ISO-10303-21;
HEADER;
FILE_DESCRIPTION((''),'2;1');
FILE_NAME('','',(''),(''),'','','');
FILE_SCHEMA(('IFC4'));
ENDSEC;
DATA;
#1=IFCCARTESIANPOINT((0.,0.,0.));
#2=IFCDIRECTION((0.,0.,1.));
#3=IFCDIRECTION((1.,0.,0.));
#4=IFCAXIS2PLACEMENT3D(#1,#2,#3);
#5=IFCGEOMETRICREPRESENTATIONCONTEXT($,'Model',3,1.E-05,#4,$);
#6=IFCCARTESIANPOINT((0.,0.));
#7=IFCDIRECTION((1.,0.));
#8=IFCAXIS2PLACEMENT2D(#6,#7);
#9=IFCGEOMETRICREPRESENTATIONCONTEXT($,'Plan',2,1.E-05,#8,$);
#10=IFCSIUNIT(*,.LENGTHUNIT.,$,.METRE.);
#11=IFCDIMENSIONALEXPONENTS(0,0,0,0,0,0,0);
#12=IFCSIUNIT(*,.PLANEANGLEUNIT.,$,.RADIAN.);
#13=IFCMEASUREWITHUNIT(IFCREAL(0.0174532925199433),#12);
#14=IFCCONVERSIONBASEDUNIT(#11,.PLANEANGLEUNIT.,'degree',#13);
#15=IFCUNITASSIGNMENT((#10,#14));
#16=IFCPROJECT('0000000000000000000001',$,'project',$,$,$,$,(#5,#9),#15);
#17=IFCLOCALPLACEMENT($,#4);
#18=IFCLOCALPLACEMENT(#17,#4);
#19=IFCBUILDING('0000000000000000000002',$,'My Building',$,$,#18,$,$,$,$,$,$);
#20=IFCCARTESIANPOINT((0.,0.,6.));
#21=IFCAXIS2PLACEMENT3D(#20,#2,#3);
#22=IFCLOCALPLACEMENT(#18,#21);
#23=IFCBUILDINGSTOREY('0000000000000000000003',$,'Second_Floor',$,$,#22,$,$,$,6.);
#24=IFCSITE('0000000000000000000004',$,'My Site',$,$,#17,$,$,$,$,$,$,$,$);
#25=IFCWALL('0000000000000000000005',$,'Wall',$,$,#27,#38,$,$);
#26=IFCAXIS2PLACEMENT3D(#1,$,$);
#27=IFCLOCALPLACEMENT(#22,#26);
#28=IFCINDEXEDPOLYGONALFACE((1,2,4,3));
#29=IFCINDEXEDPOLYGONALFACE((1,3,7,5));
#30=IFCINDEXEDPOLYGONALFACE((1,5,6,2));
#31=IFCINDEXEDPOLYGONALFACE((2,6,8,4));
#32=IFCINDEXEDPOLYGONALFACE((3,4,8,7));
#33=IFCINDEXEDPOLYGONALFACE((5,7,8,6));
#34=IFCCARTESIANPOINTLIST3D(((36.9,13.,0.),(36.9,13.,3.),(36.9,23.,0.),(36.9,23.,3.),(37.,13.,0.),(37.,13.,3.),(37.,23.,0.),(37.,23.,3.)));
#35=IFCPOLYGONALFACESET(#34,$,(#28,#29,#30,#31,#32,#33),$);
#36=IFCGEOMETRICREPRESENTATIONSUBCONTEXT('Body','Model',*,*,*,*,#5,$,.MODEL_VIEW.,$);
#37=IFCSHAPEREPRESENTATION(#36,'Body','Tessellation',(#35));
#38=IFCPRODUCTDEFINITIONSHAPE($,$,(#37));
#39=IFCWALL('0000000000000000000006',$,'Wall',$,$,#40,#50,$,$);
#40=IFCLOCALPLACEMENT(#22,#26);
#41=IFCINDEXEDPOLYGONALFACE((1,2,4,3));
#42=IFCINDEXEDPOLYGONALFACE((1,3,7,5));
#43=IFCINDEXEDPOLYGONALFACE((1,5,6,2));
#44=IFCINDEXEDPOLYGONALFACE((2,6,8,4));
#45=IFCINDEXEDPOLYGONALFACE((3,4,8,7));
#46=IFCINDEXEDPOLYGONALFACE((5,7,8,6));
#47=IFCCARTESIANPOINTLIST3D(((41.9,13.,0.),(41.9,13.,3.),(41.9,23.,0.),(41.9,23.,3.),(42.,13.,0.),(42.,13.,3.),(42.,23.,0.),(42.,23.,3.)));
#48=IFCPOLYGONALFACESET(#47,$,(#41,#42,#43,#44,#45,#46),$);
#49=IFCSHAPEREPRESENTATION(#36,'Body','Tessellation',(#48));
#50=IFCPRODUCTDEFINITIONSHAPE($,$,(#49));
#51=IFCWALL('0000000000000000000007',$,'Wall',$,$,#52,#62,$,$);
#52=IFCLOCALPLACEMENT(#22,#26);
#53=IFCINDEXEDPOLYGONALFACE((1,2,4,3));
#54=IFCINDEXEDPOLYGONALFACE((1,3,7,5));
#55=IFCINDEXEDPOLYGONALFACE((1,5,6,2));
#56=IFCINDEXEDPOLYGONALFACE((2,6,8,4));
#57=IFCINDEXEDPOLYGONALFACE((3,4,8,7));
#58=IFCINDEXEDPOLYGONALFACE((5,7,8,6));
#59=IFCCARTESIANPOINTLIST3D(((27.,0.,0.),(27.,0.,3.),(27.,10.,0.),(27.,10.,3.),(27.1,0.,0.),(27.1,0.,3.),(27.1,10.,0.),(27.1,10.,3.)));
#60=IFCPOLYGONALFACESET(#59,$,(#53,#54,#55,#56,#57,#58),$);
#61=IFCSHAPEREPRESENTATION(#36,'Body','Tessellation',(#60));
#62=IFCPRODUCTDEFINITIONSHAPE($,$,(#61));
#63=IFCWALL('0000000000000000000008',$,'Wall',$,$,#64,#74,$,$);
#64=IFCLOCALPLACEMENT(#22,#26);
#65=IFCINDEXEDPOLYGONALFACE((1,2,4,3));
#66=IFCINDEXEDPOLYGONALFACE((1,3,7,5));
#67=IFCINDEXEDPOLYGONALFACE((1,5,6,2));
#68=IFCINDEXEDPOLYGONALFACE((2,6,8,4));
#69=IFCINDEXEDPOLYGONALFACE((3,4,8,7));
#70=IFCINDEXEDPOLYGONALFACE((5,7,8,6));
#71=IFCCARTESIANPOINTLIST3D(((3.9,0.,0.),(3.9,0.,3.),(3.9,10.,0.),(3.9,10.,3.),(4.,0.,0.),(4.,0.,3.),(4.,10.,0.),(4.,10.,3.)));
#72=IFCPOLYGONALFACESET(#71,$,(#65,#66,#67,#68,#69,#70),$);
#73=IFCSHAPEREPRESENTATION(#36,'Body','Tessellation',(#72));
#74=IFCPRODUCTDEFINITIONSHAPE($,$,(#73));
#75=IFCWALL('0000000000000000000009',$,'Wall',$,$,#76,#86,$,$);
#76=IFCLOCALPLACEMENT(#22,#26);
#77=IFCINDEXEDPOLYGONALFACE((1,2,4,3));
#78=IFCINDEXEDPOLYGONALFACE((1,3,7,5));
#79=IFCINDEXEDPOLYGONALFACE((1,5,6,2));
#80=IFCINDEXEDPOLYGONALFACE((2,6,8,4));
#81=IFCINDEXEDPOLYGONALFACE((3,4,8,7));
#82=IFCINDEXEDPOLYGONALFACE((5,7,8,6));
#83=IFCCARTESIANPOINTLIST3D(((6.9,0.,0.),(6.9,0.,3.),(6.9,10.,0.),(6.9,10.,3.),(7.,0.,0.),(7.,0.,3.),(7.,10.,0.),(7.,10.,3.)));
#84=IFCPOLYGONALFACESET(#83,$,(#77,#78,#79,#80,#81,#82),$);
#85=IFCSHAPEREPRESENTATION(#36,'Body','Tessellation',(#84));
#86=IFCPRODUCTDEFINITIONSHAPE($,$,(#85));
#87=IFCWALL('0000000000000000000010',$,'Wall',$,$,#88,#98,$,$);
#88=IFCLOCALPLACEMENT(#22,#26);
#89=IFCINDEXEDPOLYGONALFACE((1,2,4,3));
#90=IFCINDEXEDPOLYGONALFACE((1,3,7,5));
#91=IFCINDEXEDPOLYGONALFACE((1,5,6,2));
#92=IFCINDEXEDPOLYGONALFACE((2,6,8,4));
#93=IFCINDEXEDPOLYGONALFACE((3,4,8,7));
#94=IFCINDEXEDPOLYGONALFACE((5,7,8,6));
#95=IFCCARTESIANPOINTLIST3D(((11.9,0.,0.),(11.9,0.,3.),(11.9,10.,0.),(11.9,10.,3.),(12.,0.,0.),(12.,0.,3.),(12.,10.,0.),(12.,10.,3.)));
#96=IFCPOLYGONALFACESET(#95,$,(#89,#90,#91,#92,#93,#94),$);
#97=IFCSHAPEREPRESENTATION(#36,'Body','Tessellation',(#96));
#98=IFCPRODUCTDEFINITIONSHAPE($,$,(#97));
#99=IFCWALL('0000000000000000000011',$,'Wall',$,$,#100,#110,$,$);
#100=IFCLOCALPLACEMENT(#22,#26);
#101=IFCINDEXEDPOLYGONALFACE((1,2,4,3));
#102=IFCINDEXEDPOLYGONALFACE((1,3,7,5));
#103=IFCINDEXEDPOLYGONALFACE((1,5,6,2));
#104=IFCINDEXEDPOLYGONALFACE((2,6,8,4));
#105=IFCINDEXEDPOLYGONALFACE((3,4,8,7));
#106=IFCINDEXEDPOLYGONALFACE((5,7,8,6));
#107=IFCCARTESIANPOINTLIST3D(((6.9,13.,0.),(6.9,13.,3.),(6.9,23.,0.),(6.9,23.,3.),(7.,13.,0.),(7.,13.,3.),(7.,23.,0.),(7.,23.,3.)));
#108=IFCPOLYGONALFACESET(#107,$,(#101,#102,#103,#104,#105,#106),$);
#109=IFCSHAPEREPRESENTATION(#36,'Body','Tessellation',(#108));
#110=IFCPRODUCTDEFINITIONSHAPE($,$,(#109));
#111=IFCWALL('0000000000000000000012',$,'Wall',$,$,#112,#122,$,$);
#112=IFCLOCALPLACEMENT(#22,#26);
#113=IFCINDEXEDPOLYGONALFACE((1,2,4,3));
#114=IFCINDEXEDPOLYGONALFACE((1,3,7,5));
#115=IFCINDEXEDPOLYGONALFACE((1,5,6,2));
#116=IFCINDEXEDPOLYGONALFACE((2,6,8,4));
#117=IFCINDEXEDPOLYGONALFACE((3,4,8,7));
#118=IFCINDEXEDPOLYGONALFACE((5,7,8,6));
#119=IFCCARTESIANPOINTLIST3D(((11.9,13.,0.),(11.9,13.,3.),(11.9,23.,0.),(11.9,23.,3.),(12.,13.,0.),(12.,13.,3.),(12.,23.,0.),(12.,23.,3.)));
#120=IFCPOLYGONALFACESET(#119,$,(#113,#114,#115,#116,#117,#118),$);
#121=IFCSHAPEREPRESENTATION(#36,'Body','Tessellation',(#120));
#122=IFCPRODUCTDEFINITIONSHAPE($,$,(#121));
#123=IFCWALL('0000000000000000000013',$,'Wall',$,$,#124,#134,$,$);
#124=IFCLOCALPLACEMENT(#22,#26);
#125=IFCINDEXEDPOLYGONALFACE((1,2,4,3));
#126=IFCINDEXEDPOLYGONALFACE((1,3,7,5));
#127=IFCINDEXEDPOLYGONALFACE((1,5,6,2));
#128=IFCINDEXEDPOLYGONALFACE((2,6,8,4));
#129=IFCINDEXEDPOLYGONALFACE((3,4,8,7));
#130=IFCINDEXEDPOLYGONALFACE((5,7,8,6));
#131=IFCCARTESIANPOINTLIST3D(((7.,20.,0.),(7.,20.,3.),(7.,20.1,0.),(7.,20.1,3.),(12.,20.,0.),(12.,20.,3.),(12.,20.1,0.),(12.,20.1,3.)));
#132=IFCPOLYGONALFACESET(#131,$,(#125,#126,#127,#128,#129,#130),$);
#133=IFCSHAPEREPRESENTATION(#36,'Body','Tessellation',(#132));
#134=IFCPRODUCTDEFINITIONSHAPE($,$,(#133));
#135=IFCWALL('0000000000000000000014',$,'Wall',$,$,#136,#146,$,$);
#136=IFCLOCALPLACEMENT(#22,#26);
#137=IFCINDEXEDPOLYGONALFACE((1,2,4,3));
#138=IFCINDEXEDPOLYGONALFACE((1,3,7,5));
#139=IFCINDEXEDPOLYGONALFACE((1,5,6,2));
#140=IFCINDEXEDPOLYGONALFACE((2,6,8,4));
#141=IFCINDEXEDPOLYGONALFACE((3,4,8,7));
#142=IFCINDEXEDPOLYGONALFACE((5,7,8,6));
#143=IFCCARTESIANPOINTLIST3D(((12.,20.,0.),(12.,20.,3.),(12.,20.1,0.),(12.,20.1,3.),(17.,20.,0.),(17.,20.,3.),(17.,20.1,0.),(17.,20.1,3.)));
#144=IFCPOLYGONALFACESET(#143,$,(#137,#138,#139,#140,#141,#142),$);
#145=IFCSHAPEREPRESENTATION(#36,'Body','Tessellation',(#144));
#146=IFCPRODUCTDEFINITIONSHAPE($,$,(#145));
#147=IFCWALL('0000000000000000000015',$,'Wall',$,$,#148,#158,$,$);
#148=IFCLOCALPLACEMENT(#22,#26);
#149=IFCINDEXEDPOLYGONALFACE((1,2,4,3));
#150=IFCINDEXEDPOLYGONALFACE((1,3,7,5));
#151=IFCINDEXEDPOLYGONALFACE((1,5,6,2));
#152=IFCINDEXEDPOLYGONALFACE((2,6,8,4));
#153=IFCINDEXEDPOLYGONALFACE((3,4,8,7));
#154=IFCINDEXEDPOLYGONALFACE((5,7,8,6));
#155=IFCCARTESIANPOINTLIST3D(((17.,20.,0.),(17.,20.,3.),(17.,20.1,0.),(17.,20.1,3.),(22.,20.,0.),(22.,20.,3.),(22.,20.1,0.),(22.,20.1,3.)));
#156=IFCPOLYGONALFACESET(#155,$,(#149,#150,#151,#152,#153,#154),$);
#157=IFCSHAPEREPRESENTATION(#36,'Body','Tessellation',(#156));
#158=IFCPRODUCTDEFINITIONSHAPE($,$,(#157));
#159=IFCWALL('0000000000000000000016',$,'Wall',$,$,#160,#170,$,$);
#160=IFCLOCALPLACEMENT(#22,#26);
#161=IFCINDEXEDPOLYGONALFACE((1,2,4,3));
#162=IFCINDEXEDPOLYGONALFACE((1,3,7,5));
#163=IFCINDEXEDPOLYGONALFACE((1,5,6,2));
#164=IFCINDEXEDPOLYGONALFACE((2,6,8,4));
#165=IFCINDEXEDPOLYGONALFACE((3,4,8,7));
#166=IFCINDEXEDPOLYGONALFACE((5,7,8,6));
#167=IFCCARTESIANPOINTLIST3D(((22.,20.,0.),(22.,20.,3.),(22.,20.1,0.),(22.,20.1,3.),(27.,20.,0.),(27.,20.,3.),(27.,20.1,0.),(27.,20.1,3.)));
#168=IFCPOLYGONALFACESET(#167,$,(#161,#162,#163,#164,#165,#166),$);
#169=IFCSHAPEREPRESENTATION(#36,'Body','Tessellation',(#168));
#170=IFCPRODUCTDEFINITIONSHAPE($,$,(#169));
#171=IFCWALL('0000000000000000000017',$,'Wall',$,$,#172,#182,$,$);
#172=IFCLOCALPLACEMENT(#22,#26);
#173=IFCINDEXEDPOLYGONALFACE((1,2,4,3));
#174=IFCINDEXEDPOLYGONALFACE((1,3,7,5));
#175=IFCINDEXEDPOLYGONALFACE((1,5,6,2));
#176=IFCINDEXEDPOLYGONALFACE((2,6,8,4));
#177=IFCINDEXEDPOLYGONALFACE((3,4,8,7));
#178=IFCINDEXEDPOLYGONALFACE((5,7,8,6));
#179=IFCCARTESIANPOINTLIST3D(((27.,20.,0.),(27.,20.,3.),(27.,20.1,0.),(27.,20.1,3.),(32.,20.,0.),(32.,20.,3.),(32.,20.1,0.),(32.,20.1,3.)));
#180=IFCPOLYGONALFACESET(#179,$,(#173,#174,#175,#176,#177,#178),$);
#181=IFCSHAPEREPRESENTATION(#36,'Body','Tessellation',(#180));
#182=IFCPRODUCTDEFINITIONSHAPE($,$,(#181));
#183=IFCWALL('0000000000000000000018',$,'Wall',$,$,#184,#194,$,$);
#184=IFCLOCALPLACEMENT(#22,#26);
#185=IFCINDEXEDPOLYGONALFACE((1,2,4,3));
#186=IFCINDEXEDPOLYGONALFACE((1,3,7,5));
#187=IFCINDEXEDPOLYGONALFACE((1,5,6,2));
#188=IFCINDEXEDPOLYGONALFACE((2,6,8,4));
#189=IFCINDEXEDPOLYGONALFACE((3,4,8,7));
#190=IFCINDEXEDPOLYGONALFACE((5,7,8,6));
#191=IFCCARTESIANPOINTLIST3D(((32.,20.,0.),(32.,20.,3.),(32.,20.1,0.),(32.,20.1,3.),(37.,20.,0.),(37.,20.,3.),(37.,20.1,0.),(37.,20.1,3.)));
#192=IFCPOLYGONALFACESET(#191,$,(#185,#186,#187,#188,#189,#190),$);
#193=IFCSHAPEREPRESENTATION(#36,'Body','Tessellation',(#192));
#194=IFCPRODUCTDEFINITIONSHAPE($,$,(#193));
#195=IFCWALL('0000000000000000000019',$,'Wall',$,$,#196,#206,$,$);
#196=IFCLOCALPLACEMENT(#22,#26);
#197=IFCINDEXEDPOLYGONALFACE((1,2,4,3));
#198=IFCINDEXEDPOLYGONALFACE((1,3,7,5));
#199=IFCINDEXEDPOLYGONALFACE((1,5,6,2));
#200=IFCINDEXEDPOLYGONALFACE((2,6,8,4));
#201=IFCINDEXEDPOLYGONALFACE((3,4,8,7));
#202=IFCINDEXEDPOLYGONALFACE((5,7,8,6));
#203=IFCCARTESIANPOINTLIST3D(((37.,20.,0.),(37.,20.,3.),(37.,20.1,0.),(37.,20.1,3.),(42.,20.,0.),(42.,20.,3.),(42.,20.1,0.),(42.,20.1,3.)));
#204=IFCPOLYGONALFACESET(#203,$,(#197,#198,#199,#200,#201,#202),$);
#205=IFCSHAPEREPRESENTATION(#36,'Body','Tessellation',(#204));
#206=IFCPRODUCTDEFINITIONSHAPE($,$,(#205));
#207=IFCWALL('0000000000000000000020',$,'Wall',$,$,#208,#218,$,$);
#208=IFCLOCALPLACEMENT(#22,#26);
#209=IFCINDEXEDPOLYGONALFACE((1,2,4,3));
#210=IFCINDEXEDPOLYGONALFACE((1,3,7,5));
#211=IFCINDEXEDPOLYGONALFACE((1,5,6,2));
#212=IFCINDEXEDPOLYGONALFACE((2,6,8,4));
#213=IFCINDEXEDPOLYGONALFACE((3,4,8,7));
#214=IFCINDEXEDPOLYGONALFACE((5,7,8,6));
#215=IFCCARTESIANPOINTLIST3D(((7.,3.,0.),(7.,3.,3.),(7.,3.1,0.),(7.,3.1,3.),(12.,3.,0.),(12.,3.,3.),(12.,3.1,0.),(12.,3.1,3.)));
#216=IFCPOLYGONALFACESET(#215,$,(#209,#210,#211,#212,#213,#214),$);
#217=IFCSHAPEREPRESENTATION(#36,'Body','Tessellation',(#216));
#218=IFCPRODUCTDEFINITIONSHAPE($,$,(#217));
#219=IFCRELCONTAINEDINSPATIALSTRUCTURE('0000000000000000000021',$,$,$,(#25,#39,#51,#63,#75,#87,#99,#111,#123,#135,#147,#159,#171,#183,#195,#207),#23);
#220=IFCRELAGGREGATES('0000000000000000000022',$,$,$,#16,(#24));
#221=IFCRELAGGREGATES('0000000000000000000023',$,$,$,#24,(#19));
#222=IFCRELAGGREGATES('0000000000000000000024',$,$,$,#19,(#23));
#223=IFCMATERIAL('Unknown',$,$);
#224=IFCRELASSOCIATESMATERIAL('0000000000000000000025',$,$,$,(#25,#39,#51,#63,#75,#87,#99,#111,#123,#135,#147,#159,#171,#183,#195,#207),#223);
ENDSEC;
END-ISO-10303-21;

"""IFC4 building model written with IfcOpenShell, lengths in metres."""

from ifc_helpers import new_model, entity, si_unit, converted_unit, frame, frame_2d, origin, origin_with_axes, origin_2d_with_axis, place, context, subcontext, project, spatial, rectangle, extrude, material, element, save


model = new_model("IFC4")

# Units and contexts
model_context = context("Model", 3, precision=1e-05, world=origin_with_axes())
plan_context = context("Plan", 2, precision=1e-05, world=origin_2d_with_axis())
body_context = subcontext(model_context, "Body", "Model", "MODEL_VIEW")
ifc_project = project(units=[si_unit("LENGTHUNIT", "METRE"), converted_unit("PLANEANGLEUNIT", "degree", entity("IfcReal", 0.0174532925199433), si_unit("PLANEANGLEUNIT", "RADIAN"), dimensions=[0, 0, 0, 0, 0, 0, 0])], contexts=[model_context, plan_context])

# Site, building, storey
site_placement = place(None, origin_with_axes())
site = spatial("IfcSite", under=ifc_project, at=site_placement, Name="My Site")
building_placement = place(site_placement, origin_with_axes())
building = spatial("IfcBuilding", under=site, at=building_placement, Name="My Building")
storey_placement = place(building_placement, frame((0.0, 0.0, 6.0), z_axis=(0.0, 0.0, 1.0), x_axis=(1.0, 0.0, 0.0)))
storey = spatial("IfcBuildingStorey", under=building, at=storey_placement, Name="Second_Floor", Elevation=6.0)

# Walls
ifc_material = material(Name="Unknown")
wall_1_placement = place(storey_placement, origin_with_axes())
element("IfcWall", 1, at=wall_1_placement, inside=storey, material=ifc_material, Name="Wall", context=body_context, shape_type="SweptSolid", body=[
    extrude(rectangle(XDim=0.1, YDim=10.0, at=frame_2d((36.95, 18.0))), origin(), (0.0, 0.0, 1.0), 3.0),
])
wall_2_placement = place(storey_placement, origin_with_axes())
element("IfcWall", 2, at=wall_2_placement, inside=storey, material=ifc_material, Name="Wall", context=body_context, shape_type="SweptSolid", body=[
    extrude(rectangle(XDim=0.1, YDim=10.0, at=frame_2d((41.95, 18.0))), origin(), (0.0, 0.0, 1.0), 3.0),
])
wall_3_placement = place(storey_placement, origin_with_axes())
element("IfcWall", 3, at=wall_3_placement, inside=storey, material=ifc_material, Name="Wall", context=body_context, shape_type="SweptSolid", body=[
    extrude(rectangle(XDim=0.1, YDim=10.0, at=frame_2d((27.05, 5.0))), origin(), (0.0, 0.0, 1.0), 3.0),
])
wall_4_placement = place(storey_placement, origin_with_axes())
element("IfcWall", 4, at=wall_4_placement, inside=storey, material=ifc_material, Name="Wall", context=body_context, shape_type="SweptSolid", body=[
    extrude(rectangle(XDim=0.1, YDim=10.0, at=frame_2d((3.95, 5.0))), origin(), (0.0, 0.0, 1.0), 3.0),
])
wall_5_placement = place(storey_placement, origin_with_axes())
element("IfcWall", 5, at=wall_5_placement, inside=storey, material=ifc_material, Name="Wall", context=body_context, shape_type="SweptSolid", body=[
    extrude(rectangle(XDim=0.1, YDim=10.0, at=frame_2d((6.95, 5.0))), origin(), (0.0, 0.0, 1.0), 3.0),
])
wall_6_placement = place(storey_placement, origin_with_axes())
element("IfcWall", 6, at=wall_6_placement, inside=storey, material=ifc_material, Name="Wall", context=body_context, shape_type="SweptSolid", body=[
    extrude(rectangle(XDim=0.1, YDim=10.0, at=frame_2d((11.95, 5.0))), origin(), (0.0, 0.0, 1.0), 3.0),
])
wall_7_placement = place(storey_placement, origin_with_axes())
element("IfcWall", 7, at=wall_7_placement, inside=storey, material=ifc_material, Name="Wall", context=body_context, shape_type="SweptSolid", body=[
    extrude(rectangle(XDim=0.1, YDim=10.0, at=frame_2d((6.95, 18.0))), origin(), (0.0, 0.0, 1.0), 3.0),
])
wall_8_placement = place(storey_placement, origin_with_axes())
element("IfcWall", 8, at=wall_8_placement, inside=storey, material=ifc_material, Name="Wall", context=body_context, shape_type="SweptSolid", body=[
    extrude(rectangle(XDim=0.1, YDim=10.0, at=frame_2d((11.95, 18.0))), origin(), (0.0, 0.0, 1.0), 3.0),
])
wall_9_placement = place(storey_placement, origin_with_axes())
element("IfcWall", 9, at=wall_9_placement, inside=storey, material=ifc_material, Name="Wall", context=body_context, shape_type="SweptSolid", body=[
    extrude(rectangle(XDim=5.0, YDim=0.1, at=frame_2d((9.5, 20.05))), origin(), (0.0, 0.0, 1.0), 3.0),
])
wall_10_placement = place(storey_placement, origin_with_axes())
element("IfcWall", 10, at=wall_10_placement, inside=storey, material=ifc_material, Name="Wall", context=body_context, shape_type="SweptSolid", body=[
    extrude(rectangle(XDim=5.0, YDim=0.1, at=frame_2d((14.5, 20.05))), origin(), (0.0, 0.0, 1.0), 3.0),
])
wall_11_placement = place(storey_placement, origin_with_axes())
element("IfcWall", 11, at=wall_11_placement, inside=storey, material=ifc_material, Name="Wall", context=body_context, shape_type="SweptSolid", body=[
    extrude(rectangle(XDim=5.0, YDim=0.1, at=frame_2d((19.5, 20.05))), origin(), (0.0, 0.0, 1.0), 3.0),
])
wall_12_placement = place(storey_placement, origin_with_axes())
element("IfcWall", 12, at=wall_12_placement, inside=storey, material=ifc_material, Name="Wall", context=body_context, shape_type="SweptSolid", body=[
    extrude(rectangle(XDim=5.0, YDim=0.1, at=frame_2d((24.5, 20.05))), origin(), (0.0, 0.0, 1.0), 3.0),
])
wall_13_placement = place(storey_placement, origin_with_axes())
element("IfcWall", 13, at=wall_13_placement, inside=storey, material=ifc_material, Name="Wall", context=body_context, shape_type="SweptSolid", body=[
    extrude(rectangle(XDim=5.0, YDim=0.1, at=frame_2d((29.5, 20.05))), origin(), (0.0, 0.0, 1.0), 3.0),
])
wall_14_placement = place(storey_placement, origin_with_axes())
element("IfcWall", 14, at=wall_14_placement, inside=storey, material=ifc_material, Name="Wall", context=body_context, shape_type="SweptSolid", body=[
    extrude(rectangle(XDim=5.0, YDim=0.1, at=frame_2d((34.5, 20.05))), origin(), (0.0, 0.0, 1.0), 3.0),
])
wall_15_placement = place(storey_placement, origin_with_axes())
element("IfcWall", 15, at=wall_15_placement, inside=storey, material=ifc_material, Name="Wall", context=body_context, shape_type="SweptSolid", body=[
    extrude(rectangle(XDim=5.0, YDim=0.1, at=frame_2d((39.5, 20.05))), origin(), (0.0, 0.0, 1.0), 3.0),
])
wall_16_placement = place(storey_placement, origin_with_axes())
element("IfcWall", 16, at=wall_16_placement, inside=storey, material=ifc_material, Name="Wall", context=body_context, shape_type="SweptSolid", body=[
    extrude(rectangle(XDim=5.0, YDim=0.1, at=frame_2d((9.5, 3.05))), origin(), (0.0, 0.0, 1.0), 3.0),
])

save(model, "model.ifc")
